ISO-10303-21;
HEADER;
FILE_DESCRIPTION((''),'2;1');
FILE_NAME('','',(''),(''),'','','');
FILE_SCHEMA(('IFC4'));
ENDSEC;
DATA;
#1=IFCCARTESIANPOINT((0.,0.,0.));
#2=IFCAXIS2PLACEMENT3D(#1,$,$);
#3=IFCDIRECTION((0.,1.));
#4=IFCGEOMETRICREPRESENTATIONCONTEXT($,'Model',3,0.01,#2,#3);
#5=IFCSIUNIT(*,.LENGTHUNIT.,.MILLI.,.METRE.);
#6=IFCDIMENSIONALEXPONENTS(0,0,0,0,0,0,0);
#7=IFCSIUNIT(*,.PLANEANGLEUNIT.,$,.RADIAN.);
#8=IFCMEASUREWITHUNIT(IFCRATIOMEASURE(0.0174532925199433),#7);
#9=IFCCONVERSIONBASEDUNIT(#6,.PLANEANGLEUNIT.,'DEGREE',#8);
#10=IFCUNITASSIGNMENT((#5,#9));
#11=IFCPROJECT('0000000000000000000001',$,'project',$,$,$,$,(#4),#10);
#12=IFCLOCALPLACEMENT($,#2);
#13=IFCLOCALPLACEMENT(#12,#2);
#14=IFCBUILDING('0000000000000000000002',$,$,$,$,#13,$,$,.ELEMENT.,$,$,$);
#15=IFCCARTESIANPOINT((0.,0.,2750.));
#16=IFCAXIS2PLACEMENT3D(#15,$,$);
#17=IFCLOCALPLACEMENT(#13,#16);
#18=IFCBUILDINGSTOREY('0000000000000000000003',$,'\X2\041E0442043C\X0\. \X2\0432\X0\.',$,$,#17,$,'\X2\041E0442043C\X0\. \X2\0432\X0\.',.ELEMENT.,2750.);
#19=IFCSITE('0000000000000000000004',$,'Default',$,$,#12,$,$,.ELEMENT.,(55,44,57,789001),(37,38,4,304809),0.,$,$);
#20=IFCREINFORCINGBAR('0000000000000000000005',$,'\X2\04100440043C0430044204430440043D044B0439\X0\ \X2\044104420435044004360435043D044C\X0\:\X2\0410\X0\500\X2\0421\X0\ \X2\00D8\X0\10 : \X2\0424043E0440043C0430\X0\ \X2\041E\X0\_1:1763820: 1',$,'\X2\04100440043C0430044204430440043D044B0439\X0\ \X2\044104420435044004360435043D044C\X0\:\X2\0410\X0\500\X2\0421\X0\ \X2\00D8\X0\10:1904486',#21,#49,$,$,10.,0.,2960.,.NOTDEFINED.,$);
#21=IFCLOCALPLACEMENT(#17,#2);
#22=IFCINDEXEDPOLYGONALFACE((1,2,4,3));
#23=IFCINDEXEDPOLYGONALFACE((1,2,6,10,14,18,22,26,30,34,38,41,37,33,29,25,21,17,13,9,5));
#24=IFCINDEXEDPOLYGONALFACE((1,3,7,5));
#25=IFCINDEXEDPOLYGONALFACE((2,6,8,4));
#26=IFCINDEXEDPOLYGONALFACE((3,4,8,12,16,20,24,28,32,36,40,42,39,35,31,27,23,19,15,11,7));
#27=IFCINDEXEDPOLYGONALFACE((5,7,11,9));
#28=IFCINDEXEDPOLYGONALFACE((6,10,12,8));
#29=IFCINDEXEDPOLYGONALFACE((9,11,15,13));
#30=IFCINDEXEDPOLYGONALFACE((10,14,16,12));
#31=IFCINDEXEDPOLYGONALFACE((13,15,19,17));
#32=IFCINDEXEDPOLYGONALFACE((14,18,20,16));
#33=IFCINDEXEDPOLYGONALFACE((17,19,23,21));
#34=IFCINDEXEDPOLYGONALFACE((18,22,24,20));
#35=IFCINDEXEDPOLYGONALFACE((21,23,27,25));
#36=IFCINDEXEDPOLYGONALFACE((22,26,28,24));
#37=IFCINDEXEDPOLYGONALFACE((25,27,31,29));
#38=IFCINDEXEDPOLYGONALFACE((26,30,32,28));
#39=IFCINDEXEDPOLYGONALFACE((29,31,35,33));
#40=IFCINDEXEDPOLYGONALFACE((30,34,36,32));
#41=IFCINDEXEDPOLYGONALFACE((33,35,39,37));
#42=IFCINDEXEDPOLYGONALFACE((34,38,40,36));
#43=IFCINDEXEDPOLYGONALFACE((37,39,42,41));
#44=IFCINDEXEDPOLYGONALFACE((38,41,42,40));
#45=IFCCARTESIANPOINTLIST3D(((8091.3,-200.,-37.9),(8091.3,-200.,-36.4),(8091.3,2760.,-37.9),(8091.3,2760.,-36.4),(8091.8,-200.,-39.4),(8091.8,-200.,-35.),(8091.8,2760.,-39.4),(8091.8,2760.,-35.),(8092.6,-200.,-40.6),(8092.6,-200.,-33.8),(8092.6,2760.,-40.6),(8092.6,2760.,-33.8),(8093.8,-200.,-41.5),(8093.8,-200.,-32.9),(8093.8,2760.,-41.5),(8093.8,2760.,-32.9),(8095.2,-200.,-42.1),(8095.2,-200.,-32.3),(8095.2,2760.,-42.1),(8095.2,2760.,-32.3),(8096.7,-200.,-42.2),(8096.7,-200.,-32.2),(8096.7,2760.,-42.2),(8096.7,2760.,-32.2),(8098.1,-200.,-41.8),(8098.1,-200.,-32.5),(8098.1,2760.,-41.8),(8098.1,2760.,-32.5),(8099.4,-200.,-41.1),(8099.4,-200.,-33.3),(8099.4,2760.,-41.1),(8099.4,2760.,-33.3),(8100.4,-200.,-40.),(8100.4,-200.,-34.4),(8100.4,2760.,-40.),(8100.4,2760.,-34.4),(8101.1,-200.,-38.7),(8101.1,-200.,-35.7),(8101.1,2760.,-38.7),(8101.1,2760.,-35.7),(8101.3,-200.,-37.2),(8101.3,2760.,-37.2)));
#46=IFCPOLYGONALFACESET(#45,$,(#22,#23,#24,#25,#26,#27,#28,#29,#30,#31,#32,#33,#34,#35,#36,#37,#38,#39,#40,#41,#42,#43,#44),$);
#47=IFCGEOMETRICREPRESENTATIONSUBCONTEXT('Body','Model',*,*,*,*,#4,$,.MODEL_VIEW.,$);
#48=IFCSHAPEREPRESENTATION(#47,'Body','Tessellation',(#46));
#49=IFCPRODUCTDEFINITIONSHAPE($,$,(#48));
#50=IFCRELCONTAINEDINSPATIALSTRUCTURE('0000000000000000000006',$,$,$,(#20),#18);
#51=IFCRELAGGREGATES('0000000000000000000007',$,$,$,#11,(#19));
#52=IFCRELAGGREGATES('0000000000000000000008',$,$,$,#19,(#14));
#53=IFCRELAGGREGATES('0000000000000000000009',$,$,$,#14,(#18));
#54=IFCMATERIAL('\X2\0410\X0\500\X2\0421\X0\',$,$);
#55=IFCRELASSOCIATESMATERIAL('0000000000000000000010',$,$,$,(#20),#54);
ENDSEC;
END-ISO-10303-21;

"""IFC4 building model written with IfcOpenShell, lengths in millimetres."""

from ifc_helpers import new_model, entity, si_unit, converted_unit, direction, frame, origin, place, context, subcontext, project, spatial, material, element, save


model = new_model("IFC4")

# Units and contexts
model_context = context("Model", 3, precision=0.01, world=origin(), true_north=direction((0.0, 1.0)))
body_context = subcontext(model_context, "Body", "Model", "MODEL_VIEW")
ifc_project = project(units=[si_unit("LENGTHUNIT", "METRE", prefix="MILLI"), converted_unit("PLANEANGLEUNIT", "DEGREE", entity("IfcRatioMeasure", 0.0174532925199433), si_unit("PLANEANGLEUNIT", "RADIAN"), dimensions=[0, 0, 0, 0, 0, 0, 0])], contexts=[model_context])

# Site, building, storey
site_placement = place(None, origin())
site = spatial("IfcSite", under=ifc_project, at=site_placement, Name="Default", CompositionType="ELEMENT", RefLatitude=(55, 44, 57, 789001), RefLongitude=(37, 38, 4, 304809), RefElevation=0.0)
building_placement = place(site_placement, origin())
building = spatial("IfcBuilding", under=site, at=building_placement, CompositionType="ELEMENT")
storey_placement = place(building_placement, frame((0.0, 0.0, 2750.0)))
storey = spatial("IfcBuildingStorey", under=building, at=storey_placement, Name="Отм. в.", LongName="Отм. в.", CompositionType="ELEMENT", Elevation=2750.0)

# Reinforcing bar
ifc_material_1 = material(Name="А500С")
reinforcing_bar_1_placement = place(storey_placement, origin())
element("IfcReinforcingBar", 1, at=reinforcing_bar_1_placement, inside=storey, material=ifc_material_1, Name="Арматурный стержень:А500С Ø10 : Форма О_1:1763820: 1", ObjectType="Арматурный стержень:А500С Ø10:1904486", BarLength=2960.0, CrossSectionArea=0.0, NominalDiameter=10.0, PredefinedType="NOTDEFINED", context=body_context, shape_type="AdvancedSweptSolid", body=[
    entity("IfcSweptDiskSolid", entity("IfcCompositeCurve", [entity("IfcCompositeCurveSegment", "CONTINUOUS", True, entity("IfcPolyline", [entity("IfcCartesianPoint", [8096.3, -200.0, -37.2]), entity("IfcCartesianPoint", [8096.3, 2760.0, -37.2])]))], False), 5.0, None, 0.0, 1.0),
])

save(model, "model.ifc")
